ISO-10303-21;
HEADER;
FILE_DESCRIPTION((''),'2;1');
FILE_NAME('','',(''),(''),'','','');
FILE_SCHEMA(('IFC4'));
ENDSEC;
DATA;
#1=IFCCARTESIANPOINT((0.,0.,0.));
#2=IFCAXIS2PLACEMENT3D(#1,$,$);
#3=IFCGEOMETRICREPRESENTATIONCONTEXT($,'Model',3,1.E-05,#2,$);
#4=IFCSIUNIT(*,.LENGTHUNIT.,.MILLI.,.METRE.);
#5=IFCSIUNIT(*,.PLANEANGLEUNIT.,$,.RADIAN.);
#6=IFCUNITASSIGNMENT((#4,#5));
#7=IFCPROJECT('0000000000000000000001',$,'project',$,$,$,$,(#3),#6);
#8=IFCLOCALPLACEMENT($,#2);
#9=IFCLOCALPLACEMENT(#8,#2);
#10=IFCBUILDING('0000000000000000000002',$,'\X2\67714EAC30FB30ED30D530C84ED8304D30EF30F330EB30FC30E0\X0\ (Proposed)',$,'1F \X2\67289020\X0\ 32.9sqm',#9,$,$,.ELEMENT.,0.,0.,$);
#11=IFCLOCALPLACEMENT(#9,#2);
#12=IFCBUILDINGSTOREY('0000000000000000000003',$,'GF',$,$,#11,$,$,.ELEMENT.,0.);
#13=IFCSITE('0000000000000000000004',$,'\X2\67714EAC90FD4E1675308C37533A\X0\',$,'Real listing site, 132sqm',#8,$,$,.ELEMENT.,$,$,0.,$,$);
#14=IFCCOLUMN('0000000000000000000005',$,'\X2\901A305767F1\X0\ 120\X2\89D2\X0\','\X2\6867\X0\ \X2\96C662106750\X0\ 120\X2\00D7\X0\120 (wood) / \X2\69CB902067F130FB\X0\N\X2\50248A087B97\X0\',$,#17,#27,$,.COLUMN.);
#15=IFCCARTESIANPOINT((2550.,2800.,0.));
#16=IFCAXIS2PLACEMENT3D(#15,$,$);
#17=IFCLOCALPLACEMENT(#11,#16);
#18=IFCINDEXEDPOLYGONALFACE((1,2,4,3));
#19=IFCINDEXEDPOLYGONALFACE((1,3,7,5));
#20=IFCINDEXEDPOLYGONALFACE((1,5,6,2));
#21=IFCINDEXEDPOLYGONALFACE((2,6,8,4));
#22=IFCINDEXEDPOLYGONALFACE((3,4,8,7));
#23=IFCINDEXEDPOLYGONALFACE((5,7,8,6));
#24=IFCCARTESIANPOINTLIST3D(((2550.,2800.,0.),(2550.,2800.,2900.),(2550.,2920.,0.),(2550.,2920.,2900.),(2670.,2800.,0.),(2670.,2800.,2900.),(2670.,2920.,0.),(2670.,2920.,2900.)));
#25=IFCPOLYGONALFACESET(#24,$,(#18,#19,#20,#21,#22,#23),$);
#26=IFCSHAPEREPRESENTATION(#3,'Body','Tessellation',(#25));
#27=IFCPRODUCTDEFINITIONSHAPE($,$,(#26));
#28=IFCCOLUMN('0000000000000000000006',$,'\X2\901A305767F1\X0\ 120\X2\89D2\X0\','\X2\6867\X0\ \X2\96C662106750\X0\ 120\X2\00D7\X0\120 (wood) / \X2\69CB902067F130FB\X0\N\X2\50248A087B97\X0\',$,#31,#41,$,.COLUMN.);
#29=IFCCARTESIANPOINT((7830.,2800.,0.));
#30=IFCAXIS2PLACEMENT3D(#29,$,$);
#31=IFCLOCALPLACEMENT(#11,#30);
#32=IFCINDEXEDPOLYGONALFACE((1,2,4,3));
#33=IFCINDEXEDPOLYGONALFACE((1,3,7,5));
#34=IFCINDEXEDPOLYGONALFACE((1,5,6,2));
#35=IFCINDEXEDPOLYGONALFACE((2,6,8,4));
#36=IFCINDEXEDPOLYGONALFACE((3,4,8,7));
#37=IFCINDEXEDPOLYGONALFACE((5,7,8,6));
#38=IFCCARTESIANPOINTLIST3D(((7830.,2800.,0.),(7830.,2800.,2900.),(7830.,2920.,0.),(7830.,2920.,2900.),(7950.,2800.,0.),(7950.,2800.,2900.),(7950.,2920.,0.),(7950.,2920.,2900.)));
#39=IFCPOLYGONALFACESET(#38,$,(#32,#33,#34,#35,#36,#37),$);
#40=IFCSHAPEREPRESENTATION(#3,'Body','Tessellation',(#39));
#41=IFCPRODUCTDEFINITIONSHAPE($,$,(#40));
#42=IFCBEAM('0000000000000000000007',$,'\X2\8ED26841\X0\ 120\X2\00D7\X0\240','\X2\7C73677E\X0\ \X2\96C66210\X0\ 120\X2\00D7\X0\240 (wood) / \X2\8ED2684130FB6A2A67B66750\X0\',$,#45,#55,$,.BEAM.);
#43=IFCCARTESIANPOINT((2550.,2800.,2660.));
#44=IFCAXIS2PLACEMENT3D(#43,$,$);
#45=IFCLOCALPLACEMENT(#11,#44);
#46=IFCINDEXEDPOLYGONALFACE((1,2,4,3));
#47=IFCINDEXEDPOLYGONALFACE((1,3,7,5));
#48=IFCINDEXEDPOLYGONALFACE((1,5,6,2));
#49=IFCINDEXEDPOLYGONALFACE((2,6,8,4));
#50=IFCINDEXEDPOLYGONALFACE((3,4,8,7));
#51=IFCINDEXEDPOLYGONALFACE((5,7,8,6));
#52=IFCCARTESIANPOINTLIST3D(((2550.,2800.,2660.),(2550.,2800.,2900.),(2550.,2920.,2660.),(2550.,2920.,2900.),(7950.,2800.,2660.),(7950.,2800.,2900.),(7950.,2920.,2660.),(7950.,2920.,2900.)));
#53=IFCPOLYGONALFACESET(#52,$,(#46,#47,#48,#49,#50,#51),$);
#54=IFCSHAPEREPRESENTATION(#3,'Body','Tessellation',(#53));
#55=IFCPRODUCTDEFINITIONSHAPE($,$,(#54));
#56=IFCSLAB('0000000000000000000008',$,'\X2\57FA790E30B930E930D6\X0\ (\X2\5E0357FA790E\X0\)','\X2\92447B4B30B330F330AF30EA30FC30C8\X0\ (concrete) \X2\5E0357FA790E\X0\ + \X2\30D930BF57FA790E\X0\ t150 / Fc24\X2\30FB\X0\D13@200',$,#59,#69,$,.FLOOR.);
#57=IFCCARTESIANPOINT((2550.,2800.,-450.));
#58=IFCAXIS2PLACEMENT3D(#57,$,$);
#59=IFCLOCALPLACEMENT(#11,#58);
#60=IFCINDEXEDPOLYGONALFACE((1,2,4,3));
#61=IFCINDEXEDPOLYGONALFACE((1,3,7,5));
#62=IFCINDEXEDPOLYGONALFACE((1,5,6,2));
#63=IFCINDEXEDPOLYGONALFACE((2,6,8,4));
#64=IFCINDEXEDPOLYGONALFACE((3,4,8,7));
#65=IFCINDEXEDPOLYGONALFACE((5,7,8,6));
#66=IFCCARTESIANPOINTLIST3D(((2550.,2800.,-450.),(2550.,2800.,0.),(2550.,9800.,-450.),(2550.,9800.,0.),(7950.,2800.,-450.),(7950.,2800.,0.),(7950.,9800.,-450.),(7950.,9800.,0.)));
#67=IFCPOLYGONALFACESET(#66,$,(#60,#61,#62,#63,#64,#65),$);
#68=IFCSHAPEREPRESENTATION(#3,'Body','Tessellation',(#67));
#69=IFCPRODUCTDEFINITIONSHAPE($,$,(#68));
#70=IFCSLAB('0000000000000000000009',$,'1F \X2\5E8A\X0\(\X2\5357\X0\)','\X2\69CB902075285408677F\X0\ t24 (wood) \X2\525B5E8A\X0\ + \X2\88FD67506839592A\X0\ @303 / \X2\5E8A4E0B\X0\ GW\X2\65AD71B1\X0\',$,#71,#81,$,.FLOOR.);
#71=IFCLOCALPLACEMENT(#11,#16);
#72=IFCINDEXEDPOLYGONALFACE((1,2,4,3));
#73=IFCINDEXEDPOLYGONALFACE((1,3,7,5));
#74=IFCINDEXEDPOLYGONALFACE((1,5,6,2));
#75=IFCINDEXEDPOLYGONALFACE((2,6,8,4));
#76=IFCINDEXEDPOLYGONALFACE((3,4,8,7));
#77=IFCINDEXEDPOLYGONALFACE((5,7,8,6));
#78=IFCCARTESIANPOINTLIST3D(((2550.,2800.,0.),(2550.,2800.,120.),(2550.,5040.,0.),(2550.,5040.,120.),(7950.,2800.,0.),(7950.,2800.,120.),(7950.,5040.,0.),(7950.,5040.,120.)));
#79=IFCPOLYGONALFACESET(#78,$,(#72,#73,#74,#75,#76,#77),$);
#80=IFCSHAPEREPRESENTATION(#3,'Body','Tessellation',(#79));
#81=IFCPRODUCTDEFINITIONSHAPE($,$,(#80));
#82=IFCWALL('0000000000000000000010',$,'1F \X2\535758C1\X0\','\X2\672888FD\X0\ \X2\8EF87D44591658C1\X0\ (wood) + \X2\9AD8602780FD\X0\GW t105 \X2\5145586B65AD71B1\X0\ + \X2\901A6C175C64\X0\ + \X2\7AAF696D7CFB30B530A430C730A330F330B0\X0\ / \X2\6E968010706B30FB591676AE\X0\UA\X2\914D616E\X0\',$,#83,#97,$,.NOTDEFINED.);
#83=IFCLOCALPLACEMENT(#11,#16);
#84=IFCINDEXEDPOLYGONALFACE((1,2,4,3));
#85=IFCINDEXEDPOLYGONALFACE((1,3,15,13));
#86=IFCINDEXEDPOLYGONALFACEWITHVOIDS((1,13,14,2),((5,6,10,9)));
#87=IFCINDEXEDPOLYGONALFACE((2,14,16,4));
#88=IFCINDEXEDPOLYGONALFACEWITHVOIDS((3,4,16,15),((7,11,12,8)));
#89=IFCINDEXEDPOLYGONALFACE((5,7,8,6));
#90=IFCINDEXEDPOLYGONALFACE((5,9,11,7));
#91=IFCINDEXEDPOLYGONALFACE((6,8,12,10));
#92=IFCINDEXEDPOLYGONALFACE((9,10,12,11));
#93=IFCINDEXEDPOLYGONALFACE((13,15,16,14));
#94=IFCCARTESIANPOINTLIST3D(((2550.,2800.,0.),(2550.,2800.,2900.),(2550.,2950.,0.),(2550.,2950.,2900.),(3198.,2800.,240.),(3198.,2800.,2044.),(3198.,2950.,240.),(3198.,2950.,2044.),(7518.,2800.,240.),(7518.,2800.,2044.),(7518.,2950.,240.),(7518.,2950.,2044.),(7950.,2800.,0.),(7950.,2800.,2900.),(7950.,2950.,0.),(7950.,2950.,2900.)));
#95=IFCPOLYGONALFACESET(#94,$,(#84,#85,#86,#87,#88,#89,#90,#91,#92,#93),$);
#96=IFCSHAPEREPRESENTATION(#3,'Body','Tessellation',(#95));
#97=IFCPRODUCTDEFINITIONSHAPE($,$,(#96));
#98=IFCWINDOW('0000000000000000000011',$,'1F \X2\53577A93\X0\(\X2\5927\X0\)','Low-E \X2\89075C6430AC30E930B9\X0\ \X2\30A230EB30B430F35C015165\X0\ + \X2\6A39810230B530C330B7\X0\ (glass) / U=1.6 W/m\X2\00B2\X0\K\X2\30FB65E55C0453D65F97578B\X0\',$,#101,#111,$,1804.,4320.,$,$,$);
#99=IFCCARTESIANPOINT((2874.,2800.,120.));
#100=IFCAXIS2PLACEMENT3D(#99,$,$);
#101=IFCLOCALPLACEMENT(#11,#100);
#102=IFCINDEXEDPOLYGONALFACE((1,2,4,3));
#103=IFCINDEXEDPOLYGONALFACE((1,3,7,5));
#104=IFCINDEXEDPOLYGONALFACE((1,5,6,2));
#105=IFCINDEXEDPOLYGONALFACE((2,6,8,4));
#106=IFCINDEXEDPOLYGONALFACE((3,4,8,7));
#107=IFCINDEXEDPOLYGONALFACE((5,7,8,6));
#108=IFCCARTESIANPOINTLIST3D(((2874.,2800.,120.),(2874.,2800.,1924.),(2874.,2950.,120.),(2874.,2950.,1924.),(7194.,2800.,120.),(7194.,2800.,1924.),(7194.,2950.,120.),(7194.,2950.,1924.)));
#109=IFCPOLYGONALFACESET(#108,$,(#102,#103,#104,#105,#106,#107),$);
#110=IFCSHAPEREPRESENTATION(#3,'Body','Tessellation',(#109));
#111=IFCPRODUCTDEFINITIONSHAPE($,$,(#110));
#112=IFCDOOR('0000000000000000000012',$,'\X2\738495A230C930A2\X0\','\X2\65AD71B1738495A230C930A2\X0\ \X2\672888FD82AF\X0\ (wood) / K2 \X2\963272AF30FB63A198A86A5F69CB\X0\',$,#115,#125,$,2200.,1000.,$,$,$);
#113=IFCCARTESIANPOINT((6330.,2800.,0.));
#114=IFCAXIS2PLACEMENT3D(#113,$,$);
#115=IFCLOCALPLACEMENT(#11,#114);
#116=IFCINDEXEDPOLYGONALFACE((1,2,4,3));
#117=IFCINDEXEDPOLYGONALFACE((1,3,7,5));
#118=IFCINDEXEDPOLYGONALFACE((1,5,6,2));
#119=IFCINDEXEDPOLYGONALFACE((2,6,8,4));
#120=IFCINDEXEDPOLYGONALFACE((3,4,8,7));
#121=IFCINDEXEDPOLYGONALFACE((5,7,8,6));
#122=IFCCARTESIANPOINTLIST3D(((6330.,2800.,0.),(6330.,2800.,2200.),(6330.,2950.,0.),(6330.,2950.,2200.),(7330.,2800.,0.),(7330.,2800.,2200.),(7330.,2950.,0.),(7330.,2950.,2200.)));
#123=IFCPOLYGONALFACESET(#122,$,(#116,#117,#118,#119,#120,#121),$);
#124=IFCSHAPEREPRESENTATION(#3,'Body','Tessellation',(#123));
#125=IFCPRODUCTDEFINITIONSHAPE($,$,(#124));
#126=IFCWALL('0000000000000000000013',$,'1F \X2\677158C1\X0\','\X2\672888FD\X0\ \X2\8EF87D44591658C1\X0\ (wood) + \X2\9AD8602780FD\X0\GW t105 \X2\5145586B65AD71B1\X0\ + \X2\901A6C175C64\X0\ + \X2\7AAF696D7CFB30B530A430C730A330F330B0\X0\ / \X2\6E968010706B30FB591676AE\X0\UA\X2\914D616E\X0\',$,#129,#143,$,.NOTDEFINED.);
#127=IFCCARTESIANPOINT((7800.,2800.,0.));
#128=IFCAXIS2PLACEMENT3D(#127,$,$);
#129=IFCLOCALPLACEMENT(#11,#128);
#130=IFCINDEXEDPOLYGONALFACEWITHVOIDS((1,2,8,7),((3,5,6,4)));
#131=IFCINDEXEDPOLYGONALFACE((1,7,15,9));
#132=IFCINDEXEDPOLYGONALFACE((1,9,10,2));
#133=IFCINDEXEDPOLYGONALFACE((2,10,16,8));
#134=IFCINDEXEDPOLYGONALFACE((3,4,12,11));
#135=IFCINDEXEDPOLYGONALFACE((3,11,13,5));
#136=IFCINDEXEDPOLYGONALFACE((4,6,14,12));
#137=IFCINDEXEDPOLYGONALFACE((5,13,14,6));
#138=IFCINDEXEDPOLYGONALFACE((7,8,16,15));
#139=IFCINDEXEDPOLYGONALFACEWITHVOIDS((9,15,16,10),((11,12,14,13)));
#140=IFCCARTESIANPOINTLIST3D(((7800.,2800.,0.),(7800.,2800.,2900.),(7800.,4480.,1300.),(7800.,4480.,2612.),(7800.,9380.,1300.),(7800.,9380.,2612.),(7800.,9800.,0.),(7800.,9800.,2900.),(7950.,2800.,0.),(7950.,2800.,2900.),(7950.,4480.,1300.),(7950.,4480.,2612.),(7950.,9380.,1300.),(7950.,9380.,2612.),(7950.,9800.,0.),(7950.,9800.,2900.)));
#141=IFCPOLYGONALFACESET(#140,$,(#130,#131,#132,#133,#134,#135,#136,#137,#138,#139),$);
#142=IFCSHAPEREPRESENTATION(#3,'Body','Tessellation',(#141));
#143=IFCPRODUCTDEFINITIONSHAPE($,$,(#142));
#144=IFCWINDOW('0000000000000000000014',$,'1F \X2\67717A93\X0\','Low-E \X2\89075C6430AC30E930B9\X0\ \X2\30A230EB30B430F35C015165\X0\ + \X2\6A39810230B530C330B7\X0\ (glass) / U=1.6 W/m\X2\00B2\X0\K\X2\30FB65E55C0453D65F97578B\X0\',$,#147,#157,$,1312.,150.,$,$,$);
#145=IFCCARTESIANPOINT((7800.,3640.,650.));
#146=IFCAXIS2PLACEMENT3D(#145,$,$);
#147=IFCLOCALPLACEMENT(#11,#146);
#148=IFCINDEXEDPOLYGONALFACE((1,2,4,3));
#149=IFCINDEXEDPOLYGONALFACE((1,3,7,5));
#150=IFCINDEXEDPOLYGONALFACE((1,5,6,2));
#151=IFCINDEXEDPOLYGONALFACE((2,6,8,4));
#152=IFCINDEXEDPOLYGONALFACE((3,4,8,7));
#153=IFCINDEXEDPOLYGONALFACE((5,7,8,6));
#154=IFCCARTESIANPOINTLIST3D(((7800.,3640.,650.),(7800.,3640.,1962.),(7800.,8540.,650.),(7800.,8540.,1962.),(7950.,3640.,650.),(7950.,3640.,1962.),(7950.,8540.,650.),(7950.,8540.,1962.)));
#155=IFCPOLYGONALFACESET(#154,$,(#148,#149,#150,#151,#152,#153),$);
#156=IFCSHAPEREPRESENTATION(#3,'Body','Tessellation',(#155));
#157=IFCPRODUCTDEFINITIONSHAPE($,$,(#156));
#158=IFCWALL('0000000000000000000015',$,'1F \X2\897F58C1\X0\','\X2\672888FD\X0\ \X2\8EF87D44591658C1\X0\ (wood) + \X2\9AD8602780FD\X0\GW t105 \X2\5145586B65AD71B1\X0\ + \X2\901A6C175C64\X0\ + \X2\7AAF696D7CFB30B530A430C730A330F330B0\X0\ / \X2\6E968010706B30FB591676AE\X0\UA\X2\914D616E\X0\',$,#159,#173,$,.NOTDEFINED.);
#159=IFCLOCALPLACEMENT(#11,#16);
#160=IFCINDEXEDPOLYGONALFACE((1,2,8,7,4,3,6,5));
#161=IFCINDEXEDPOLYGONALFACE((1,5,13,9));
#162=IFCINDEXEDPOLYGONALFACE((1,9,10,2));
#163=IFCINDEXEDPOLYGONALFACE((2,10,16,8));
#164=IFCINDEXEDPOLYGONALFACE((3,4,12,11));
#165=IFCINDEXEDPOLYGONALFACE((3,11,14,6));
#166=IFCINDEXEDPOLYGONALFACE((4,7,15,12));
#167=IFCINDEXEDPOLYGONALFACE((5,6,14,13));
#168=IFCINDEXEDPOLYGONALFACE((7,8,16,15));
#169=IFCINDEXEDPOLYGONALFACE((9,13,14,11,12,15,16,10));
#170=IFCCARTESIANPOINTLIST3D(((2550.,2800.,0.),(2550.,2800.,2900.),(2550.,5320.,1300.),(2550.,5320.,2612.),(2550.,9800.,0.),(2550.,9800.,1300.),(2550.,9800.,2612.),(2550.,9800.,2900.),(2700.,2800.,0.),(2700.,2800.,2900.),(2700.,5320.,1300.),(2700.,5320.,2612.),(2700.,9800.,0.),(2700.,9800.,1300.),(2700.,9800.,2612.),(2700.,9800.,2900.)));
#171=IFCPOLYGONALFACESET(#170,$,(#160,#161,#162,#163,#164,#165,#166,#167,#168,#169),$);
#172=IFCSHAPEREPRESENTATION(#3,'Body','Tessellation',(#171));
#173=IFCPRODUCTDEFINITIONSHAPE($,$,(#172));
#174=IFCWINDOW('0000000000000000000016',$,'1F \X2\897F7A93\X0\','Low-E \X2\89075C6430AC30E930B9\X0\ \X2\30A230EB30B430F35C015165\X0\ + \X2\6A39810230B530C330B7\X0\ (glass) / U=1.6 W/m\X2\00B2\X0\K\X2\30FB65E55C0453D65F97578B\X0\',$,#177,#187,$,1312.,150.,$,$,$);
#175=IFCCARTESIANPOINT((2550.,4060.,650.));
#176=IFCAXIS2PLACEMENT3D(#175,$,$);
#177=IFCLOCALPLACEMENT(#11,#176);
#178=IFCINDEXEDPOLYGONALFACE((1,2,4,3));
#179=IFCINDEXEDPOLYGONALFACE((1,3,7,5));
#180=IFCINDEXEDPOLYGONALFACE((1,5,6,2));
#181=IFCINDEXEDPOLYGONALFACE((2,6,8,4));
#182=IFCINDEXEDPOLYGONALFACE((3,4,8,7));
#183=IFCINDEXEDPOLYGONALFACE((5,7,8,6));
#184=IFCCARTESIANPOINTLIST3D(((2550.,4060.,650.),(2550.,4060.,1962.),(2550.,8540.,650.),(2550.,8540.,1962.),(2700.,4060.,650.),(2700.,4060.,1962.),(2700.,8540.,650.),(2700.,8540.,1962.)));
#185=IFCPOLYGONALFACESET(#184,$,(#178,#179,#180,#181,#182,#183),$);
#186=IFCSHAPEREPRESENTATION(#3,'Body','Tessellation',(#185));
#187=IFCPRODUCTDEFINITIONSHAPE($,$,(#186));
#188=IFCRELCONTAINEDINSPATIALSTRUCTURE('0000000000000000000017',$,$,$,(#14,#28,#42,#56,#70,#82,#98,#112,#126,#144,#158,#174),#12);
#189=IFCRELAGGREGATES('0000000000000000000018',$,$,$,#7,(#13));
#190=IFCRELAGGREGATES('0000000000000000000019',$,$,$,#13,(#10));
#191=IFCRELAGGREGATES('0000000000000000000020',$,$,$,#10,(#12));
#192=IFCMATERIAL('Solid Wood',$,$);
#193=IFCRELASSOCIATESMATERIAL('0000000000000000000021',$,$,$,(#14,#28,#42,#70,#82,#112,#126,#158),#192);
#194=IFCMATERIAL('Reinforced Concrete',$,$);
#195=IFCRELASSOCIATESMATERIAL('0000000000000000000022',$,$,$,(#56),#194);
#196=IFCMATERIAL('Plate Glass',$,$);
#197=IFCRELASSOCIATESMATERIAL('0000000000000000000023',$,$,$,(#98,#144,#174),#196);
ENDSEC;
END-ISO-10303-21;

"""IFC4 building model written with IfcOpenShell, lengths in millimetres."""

from ifc_helpers import new_model, si_unit, frame, frame_2d, origin, place, context, project, spatial, rectangle, extrude, material, element, fill, save


model = new_model("IFC4")

# Units and contexts
model_context = context("Model", 3, precision=1e-05, world=origin())
ifc_project = project(units=[si_unit("LENGTHUNIT", "METRE", prefix="MILLI"), si_unit("PLANEANGLEUNIT", "RADIAN")], contexts=[model_context])

# Site, building, storey
site_placement = place(None, origin())
site = spatial("IfcSite", under=ifc_project, at=site_placement, Name="東京都世田谷区", ObjectType="Real listing site, 132sqm", CompositionType="ELEMENT", RefElevation=0.0)
building_placement = place(site_placement, origin())
building = spatial("IfcBuilding", under=site, at=building_placement, Name="東京・ロフト付きワンルーム (Proposed)", ObjectType="1F 木造 32.9sqm", CompositionType="ELEMENT", ElevationOfRefHeight=0.0, ElevationOfTerrain=0.0)
storey_placement = place(building_placement, origin())
storey = spatial("IfcBuildingStorey", under=building, at=storey_placement, Name="GF", CompositionType="ELEMENT", Elevation=0.0)

# Columns
ifc_material_1 = material(Name="Solid Wood")
column_1_placement = place(storey_placement, frame((2550.0, 2800.0, 0.0)))
element("IfcColumn", 1, at=column_1_placement, inside=storey, material=ifc_material_1, Name="通し柱 120角", Description="桧 集成材 120×120 (wood) / 構造柱・N値計算", PredefinedType="COLUMN", context=model_context, shape_type="SweptSolid", body=[
    extrude(rectangle(XDim=120.0, YDim=120.0, at=frame_2d((60.0, 60.0))), frame((2550.0, 2800.0, 0.0)), (0.0, 0.0, 1.0), 2900.0),
])
column_2_placement = place(storey_placement, frame((7830.0, 2800.0, 0.0)))
element("IfcColumn", 2, at=column_2_placement, inside=storey, material=ifc_material_1, Name="通し柱 120角", Description="桧 集成材 120×120 (wood) / 構造柱・N値計算", PredefinedType="COLUMN", context=model_context, shape_type="SweptSolid", body=[
    extrude(rectangle(XDim=120.0, YDim=120.0, at=frame_2d((60.0, 60.0))), frame((7830.0, 2800.0, 0.0)), (0.0, 0.0, 1.0), 2900.0),
])

# Beam
beam_1_placement = place(storey_placement, frame((2550.0, 2800.0, 2660.0)))
element("IfcBeam", 3, at=beam_1_placement, inside=storey, material=ifc_material_1, Name="軒桁 120×240", Description="米松 集成 120×240 (wood) / 軒桁・横架材", PredefinedType="BEAM", context=model_context, shape_type="SweptSolid", body=[
    extrude(rectangle(XDim=5400.0, YDim=120.0, at=frame_2d((2700.0, 60.0))), frame((2550.0, 2800.0, 2660.0)), (0.0, 0.0, 1.0), 240.0),
])

# Slabs
ifc_material_2 = material(Name="Reinforced Concrete")
slab_1_placement = place(storey_placement, frame((2550.0, 2800.0, -450.0)))
element("IfcSlab", 4, at=slab_1_placement, inside=storey, material=ifc_material_2, Name="基礎スラブ (布基礎)", Description="鉄筋コンクリート (concrete) 布基礎 + ベタ基礎 t150 / Fc24・D13@200", PredefinedType="FLOOR", context=model_context, shape_type="SweptSolid", body=[
    extrude(rectangle(XDim=5400.0, YDim=7000.0, at=frame_2d((2700.0, 3500.0))), frame((2550.0, 2800.0, -450.0)), (0.0, 0.0, 1.0), 450.0),
])
slab_2_placement = place(storey_placement, frame((2550.0, 2800.0, 0.0)))
element("IfcSlab", 5, at=slab_2_placement, inside=storey, material=ifc_material_1, Name="1F 床(南)", Description="構造用合板 t24 (wood) 剛床 + 製材根太 @303 / 床下 GW断熱", PredefinedType="FLOOR", context=model_context, shape_type="SweptSolid", body=[
    extrude(rectangle(XDim=5400.0, YDim=2240.0, at=frame_2d((2700.0, 1120.0))), frame((2550.0, 2800.0, 0.0)), (0.0, 0.0, 1.0), 120.0),
])

# Wall, openings, window, door
wall_1_placement = place(storey_placement, frame((2550.0, 2800.0, 0.0)))
wall_1 = element("IfcWall", 6, at=wall_1_placement, inside=storey, material=ifc_material_1, Name="1F 南壁", Description="木製 軸組外壁 (wood) + 高性能GW t105 充填断熱 + 通気層 + 窯業系サイディング / 準耐火・外皮UA配慮", PredefinedType="NOTDEFINED", context=model_context, shape_type="SweptSolid", body=[
    extrude(rectangle(XDim=5400.0, YDim=150.0, at=frame_2d((2700.0, 75.0))), frame((2550.0, 2800.0, 0.0)), (0.0, 0.0, 1.0), 2900.0),
])
opening_1_placement = place(storey_placement, frame((2874.0, 2800.0, 120.0)))
opening_1 = element("IfcOpeningElement", 7, at=opening_1_placement, cuts=wall_1, PredefinedType="NOTDEFINED", context=model_context, shape_type="SweptSolid", body=[
    extrude(rectangle(XDim=4320.0, YDim=150.0, at=frame_2d((2160.0, 75.0))), frame((2874.0, 2800.0, 120.0)), (0.0, 0.0, 1.0), 1804.0),
])
opening_2_placement = place(storey_placement, frame((6330.0, 2800.0, 0.0)))
opening_2 = element("IfcOpeningElement", 8, at=opening_2_placement, cuts=wall_1, PredefinedType="NOTDEFINED", context=model_context, shape_type="SweptSolid", body=[
    extrude(rectangle(XDim=1000.0, YDim=150.0, at=frame_2d((500.0, 75.0))), frame((6330.0, 2800.0, 0.0)), (0.0, 0.0, 1.0), 2200.0),
])
ifc_material_3 = material(Name="Plate Glass")
window_1_placement = place(storey_placement, frame((2874.0, 2800.0, 120.0)))
window_1 = element("IfcWindow", 9, at=window_1_placement, inside=storey, material=ifc_material_3, Name="1F 南窓(大)", Description="Low-E 複層ガラス アルゴン封入 + 樹脂サッシ (glass) / U=1.6 W/m²K・日射取得型", OverallHeight=1804.0, OverallWidth=4320.0, context=model_context, shape_type="SweptSolid", body=[
    extrude(rectangle(XDim=4320.0, YDim=150.0, at=frame_2d((2160.0, 75.0))), frame((2874.0, 2800.0, 120.0)), (0.0, 0.0, 1.0), 1804.0),
])
fill(opening_1, window_1)
door_placement = place(storey_placement, frame((6330.0, 2800.0, 0.0)))
door = element("IfcDoor", 10, at=door_placement, inside=storey, material=ifc_material_1, Name="玄関ドア", Description="断熱玄関ドア 木製芯 (wood) / K2 防犯・採風機構", OverallHeight=2200.0, OverallWidth=1000.0, context=model_context, shape_type="SweptSolid", body=[
    extrude(rectangle(XDim=1000.0, YDim=150.0, at=frame_2d((500.0, 75.0))), frame((6330.0, 2800.0, 0.0)), (0.0, 0.0, 1.0), 2200.0),
])
fill(opening_2, door)

# Walls, openings, windows
wall_2_placement = place(storey_placement, frame((7800.0, 2800.0, 0.0)))
wall_2 = element("IfcWall", 11, at=wall_2_placement, inside=storey, material=ifc_material_1, Name="1F 東壁", Description="木製 軸組外壁 (wood) + 高性能GW t105 充填断熱 + 通気層 + 窯業系サイディング / 準耐火・外皮UA配慮", PredefinedType="NOTDEFINED", context=model_context, shape_type="SweptSolid", body=[
    extrude(rectangle(XDim=150.0, YDim=7000.0, at=frame_2d((75.0, 3500.0))), frame((7800.0, 2800.0, 0.0)), (0.0, 0.0, 1.0), 2900.0),
])
opening_3_placement = place(storey_placement, frame((7800.0, 3640.0, 650.0)))
opening_3 = element("IfcOpeningElement", 12, at=opening_3_placement, cuts=wall_2, PredefinedType="NOTDEFINED", context=model_context, shape_type="SweptSolid", body=[
    extrude(rectangle(XDim=150.0, YDim=4900.0, at=frame_2d((75.0, 2450.0))), frame((7800.0, 3640.0, 650.0)), (0.0, 0.0, 1.0), 1312.0),
])
window_2_placement = place(storey_placement, frame((7800.0, 3640.0, 650.0)))
window_2 = element("IfcWindow", 13, at=window_2_placement, inside=storey, material=ifc_material_3, Name="1F 東窓", Description="Low-E 複層ガラス アルゴン封入 + 樹脂サッシ (glass) / U=1.6 W/m²K・日射取得型", OverallHeight=1312.0, OverallWidth=150.0, context=model_context, shape_type="SweptSolid", body=[
    extrude(rectangle(XDim=150.0, YDim=4900.0, at=frame_2d((75.0, 2450.0))), frame((7800.0, 3640.0, 650.0)), (0.0, 0.0, 1.0), 1312.0),
])
fill(opening_3, window_2)
wall_3_placement = place(storey_placement, frame((2550.0, 2800.0, 0.0)))
wall_3 = element("IfcWall", 14, at=wall_3_placement, inside=storey, material=ifc_material_1, Name="1F 西壁", Description="木製 軸組外壁 (wood) + 高性能GW t105 充填断熱 + 通気層 + 窯業系サイディング / 準耐火・外皮UA配慮", PredefinedType="NOTDEFINED", context=model_context, shape_type="SweptSolid", body=[
    extrude(rectangle(XDim=150.0, YDim=7000.0, at=frame_2d((75.0, 3500.0))), frame((2550.0, 2800.0, 0.0)), (0.0, 0.0, 1.0), 2900.0),
])
opening_4_placement = place(storey_placement, frame((2550.0, 4060.0, 650.0)))
opening_4 = element("IfcOpeningElement", 15, at=opening_4_placement, cuts=wall_3, PredefinedType="NOTDEFINED", context=model_context, shape_type="SweptSolid", body=[
    extrude(rectangle(XDim=150.0, YDim=4480.0, at=frame_2d((75.0, 2240.0))), frame((2550.0, 4060.0, 650.0)), (0.0, 0.0, 1.0), 1312.0),
])
window_3_placement = place(storey_placement, frame((2550.0, 4060.0, 650.0)))
window_3 = element("IfcWindow", 16, at=window_3_placement, inside=storey, material=ifc_material_3, Name="1F 西窓", Description="Low-E 複層ガラス アルゴン封入 + 樹脂サッシ (glass) / U=1.6 W/m²K・日射取得型", OverallHeight=1312.0, OverallWidth=150.0, context=model_context, shape_type="SweptSolid", body=[
    extrude(rectangle(XDim=150.0, YDim=4480.0, at=frame_2d((75.0, 2240.0))), frame((2550.0, 4060.0, 650.0)), (0.0, 0.0, 1.0), 1312.0),
])
fill(opening_4, window_3)

save(model, "model.ifc")
